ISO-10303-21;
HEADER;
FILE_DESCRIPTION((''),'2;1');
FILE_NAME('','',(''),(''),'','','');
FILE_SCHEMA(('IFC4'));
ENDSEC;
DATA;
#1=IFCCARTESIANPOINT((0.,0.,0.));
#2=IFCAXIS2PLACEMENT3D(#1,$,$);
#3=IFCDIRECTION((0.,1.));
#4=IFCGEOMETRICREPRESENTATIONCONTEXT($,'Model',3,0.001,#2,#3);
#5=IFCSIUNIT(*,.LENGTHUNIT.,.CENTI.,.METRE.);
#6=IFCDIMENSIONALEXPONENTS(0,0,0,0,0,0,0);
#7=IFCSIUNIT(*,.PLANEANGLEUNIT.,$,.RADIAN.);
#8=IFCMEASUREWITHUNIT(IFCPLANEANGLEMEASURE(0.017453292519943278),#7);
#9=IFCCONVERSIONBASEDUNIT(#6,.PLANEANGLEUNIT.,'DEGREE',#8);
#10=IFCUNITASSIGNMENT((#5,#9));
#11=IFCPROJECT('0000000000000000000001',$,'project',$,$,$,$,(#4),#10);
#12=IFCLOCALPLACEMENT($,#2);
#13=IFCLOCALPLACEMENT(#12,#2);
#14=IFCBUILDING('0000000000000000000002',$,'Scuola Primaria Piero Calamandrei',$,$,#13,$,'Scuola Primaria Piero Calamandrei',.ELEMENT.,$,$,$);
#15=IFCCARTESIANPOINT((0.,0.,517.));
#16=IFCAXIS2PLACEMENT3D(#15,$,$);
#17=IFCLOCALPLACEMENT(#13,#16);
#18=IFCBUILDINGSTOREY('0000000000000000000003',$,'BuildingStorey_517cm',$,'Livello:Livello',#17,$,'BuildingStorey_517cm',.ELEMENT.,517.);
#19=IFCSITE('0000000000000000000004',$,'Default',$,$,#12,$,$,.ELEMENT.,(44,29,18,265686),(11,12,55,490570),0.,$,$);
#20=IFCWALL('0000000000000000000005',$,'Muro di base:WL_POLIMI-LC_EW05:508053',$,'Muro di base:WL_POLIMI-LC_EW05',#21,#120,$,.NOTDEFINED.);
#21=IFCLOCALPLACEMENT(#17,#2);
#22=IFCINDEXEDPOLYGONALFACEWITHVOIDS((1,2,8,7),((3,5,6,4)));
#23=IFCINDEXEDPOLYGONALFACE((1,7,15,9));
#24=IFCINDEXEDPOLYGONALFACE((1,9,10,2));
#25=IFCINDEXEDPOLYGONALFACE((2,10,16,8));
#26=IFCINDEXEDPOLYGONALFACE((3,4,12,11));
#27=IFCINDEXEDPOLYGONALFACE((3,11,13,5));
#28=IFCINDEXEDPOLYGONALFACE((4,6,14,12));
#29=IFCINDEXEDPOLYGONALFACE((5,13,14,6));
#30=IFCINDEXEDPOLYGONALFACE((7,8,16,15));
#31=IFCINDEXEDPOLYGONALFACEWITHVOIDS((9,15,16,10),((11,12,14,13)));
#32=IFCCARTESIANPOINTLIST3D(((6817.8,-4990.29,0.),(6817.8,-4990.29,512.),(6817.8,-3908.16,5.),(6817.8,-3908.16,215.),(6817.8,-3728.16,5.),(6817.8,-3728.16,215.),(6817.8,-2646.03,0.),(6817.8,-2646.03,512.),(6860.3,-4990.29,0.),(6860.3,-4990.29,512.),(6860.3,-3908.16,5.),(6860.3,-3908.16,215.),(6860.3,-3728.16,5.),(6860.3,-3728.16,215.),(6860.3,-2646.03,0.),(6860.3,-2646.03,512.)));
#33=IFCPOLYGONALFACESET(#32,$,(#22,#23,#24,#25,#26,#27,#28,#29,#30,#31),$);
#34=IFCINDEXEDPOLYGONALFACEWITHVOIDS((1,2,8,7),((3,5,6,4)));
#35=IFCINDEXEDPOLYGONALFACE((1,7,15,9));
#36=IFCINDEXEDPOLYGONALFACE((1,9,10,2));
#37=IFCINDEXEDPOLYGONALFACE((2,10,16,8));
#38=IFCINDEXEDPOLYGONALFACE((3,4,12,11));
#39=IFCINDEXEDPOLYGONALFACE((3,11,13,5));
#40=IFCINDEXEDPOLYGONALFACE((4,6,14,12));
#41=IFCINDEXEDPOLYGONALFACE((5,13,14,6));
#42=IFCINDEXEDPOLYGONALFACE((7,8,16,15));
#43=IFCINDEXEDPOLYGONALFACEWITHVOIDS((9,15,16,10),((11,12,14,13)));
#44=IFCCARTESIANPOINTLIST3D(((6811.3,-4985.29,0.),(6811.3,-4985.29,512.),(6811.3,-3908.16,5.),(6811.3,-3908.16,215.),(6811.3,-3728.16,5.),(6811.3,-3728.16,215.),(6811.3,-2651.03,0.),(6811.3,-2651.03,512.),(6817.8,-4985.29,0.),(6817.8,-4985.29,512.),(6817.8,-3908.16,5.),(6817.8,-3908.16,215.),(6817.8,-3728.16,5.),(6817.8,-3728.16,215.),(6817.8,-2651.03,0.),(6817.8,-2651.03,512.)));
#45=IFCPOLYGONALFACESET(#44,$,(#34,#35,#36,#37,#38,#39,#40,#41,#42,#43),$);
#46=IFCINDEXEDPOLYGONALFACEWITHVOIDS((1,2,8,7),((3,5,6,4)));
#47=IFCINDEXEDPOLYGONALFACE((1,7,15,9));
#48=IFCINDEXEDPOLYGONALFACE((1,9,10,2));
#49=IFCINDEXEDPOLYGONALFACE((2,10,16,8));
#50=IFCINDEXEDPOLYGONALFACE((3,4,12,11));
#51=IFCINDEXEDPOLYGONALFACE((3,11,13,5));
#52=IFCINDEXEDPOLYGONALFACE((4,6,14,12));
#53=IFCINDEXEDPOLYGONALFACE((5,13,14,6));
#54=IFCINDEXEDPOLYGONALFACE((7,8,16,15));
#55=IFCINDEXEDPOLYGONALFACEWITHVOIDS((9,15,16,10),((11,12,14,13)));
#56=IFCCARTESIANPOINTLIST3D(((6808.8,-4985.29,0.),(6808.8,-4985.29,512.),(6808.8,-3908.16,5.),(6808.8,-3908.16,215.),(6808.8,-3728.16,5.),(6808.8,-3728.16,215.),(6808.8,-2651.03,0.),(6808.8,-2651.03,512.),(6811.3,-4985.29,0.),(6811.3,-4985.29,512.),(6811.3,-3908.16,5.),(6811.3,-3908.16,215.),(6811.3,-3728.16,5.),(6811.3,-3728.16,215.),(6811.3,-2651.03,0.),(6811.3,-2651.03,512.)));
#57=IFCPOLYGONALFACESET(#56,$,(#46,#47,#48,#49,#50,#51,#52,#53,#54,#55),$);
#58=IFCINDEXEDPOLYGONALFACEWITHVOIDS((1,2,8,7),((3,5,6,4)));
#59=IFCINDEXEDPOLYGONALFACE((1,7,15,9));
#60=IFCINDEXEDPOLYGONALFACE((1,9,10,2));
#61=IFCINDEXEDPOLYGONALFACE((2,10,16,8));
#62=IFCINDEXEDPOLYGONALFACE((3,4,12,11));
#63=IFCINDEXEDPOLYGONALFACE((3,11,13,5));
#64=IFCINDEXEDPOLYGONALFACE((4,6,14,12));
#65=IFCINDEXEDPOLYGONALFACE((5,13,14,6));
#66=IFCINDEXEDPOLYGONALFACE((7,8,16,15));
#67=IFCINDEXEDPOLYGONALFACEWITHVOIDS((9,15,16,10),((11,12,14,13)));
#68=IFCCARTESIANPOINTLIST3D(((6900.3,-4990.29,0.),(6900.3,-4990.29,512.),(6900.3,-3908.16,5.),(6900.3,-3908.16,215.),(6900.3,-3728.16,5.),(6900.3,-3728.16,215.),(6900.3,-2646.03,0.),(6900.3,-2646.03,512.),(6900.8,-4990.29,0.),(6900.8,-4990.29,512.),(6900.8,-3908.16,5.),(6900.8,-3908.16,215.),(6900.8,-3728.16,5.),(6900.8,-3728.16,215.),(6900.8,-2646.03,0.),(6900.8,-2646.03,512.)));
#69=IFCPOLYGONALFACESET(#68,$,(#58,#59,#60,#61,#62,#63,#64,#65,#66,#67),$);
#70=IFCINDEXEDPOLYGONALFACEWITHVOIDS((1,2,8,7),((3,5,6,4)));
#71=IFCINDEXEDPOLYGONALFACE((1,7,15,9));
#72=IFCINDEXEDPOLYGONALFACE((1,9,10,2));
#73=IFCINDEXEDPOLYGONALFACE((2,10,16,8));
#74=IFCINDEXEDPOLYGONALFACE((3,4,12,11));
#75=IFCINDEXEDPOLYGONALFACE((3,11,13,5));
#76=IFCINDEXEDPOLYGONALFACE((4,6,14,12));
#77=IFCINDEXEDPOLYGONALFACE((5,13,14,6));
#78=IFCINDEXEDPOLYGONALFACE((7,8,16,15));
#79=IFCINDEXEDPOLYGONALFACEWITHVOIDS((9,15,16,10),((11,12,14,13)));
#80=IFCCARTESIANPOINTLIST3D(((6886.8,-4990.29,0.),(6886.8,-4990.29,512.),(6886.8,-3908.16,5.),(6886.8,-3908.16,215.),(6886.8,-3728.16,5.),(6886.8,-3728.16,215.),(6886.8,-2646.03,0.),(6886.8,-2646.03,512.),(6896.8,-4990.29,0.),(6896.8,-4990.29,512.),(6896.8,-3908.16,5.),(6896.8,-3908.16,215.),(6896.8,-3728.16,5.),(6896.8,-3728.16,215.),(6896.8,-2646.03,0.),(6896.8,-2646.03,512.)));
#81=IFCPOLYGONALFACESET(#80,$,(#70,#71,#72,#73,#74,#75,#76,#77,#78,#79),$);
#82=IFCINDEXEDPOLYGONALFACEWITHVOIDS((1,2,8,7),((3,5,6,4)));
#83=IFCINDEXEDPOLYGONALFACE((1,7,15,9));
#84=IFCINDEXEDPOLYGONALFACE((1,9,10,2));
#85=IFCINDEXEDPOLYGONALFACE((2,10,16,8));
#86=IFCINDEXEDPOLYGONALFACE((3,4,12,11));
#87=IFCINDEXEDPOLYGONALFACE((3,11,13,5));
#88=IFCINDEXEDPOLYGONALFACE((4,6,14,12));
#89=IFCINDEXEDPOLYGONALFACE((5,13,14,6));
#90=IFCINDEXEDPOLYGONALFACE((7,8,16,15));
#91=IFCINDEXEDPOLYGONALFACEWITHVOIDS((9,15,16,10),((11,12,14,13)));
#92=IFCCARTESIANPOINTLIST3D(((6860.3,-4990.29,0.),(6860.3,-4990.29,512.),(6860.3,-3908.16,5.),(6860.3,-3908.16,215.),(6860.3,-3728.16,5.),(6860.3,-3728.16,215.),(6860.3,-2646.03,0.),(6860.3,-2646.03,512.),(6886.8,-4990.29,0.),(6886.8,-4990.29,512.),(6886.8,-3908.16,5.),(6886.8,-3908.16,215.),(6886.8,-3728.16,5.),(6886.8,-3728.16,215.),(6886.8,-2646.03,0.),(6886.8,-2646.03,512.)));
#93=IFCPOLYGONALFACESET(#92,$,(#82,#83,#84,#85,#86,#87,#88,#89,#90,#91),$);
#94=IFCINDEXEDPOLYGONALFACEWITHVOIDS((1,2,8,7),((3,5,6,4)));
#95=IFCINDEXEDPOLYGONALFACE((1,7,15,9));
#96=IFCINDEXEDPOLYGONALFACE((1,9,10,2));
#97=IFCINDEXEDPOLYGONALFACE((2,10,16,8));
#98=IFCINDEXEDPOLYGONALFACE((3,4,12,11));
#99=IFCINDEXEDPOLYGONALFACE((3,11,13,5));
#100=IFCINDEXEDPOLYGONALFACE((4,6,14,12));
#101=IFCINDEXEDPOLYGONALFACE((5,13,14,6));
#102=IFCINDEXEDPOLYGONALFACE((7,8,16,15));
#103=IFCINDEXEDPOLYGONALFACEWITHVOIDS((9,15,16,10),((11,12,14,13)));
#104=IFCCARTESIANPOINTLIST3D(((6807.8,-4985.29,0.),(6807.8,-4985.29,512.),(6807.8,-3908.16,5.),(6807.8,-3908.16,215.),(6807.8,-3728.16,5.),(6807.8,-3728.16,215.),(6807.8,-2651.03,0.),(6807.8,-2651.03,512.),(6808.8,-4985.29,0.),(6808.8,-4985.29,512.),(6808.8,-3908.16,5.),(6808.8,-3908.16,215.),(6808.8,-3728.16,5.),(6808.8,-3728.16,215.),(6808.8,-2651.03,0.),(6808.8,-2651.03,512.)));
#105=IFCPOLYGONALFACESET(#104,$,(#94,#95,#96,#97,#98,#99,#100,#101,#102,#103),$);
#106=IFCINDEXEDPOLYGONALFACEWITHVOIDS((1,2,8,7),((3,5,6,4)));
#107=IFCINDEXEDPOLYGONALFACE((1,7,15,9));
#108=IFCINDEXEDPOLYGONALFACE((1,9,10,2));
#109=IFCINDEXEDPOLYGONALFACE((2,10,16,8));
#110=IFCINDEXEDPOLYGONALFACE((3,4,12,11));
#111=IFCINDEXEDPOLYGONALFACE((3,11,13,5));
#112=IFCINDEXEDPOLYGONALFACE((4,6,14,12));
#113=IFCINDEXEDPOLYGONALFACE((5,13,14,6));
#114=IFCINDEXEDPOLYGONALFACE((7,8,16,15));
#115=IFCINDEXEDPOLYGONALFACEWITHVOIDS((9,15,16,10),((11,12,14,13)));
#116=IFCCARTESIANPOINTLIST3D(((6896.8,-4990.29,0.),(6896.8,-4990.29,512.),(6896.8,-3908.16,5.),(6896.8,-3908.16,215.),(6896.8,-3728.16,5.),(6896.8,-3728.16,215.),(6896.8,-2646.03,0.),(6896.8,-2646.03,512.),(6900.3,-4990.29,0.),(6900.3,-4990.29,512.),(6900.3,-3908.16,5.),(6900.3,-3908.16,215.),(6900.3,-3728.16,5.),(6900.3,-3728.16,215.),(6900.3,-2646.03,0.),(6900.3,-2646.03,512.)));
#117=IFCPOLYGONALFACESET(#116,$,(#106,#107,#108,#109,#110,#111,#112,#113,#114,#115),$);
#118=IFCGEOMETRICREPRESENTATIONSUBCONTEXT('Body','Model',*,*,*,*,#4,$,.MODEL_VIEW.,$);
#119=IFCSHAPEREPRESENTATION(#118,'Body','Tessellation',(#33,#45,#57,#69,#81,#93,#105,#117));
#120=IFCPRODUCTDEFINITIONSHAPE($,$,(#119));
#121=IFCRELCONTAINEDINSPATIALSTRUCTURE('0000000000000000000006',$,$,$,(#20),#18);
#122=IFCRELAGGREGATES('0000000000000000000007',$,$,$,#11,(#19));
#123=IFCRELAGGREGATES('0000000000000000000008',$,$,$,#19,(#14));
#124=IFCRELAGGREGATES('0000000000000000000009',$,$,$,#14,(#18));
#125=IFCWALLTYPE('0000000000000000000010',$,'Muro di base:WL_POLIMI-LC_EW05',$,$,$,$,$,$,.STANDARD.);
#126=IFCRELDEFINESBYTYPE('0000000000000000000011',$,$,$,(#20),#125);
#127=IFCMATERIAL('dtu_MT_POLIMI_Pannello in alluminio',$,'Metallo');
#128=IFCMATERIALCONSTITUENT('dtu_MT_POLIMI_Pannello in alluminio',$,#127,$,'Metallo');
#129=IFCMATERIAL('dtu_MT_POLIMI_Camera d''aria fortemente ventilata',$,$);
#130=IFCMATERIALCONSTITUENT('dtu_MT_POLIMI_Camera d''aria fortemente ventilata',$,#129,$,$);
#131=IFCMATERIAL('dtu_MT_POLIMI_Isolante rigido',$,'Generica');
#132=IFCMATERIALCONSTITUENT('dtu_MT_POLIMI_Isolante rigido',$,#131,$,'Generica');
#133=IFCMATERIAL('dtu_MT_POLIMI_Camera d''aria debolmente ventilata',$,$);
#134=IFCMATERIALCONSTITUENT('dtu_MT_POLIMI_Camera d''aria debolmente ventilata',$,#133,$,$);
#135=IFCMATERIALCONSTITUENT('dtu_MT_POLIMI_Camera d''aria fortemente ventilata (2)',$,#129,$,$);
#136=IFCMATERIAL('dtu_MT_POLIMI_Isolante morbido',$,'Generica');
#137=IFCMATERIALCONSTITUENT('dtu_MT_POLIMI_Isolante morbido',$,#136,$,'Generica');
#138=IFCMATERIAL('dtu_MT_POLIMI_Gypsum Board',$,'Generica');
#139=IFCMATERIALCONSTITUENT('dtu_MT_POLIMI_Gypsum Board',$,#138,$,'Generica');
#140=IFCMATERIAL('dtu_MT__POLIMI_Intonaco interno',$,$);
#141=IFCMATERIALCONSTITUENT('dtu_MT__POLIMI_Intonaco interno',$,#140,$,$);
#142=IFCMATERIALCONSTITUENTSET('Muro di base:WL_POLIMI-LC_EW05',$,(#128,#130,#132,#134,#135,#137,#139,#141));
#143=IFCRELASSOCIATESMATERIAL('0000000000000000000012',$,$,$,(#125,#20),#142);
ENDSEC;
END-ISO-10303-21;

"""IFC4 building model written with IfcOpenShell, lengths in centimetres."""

from ifc_helpers import new_model, entity, si_unit, converted_unit, direction, frame, origin, place, context, subcontext, project, spatial, indexed_curve, outline, extrude, material, constituent, constituent_set, type_object, element, save


model = new_model("IFC4")

# Units and contexts
model_context = context("Model", 3, precision=0.001, world=origin(), true_north=direction((0.0, 1.0)))
body_context = subcontext(model_context, "Body", "Model", "MODEL_VIEW")
ifc_project = project(units=[si_unit("LENGTHUNIT", "METRE", prefix="CENTI"), converted_unit("PLANEANGLEUNIT", "DEGREE", entity("IfcPlaneAngleMeasure", 0.017453292519943278), si_unit("PLANEANGLEUNIT", "RADIAN"), dimensions=[0, 0, 0, 0, 0, 0, 0])], contexts=[model_context])

# Site, building, storey
site_placement = place(None, origin())
site = spatial("IfcSite", under=ifc_project, at=site_placement, Name="Default", CompositionType="ELEMENT", RefLatitude=(44, 29, 18, 265686), RefLongitude=(11, 12, 55, 490570), RefElevation=0.0)
building_placement = place(site_placement, origin())
building = spatial("IfcBuilding", under=site, at=building_placement, Name="Scuola Primaria Piero Calamandrei", LongName="Scuola Primaria Piero Calamandrei", CompositionType="ELEMENT")
storey_placement = place(building_placement, frame((0.0, 0.0, 517.0)))
storey = spatial("IfcBuildingStorey", under=building, at=storey_placement, Name="BuildingStorey_517cm", ObjectType="Livello:Livello", LongName="BuildingStorey_517cm", CompositionType="ELEMENT", Elevation=517.0)

# Wall, opening
ifc_material_1 = material(Name="dtu_MT_POLIMI_Pannello in alluminio", Category="Metallo")
ifc_constituent_1 = constituent(ifc_material_1, Name="dtu_MT_POLIMI_Pannello in alluminio", Category="Metallo")
ifc_material_2 = material(Name="dtu_MT_POLIMI_Camera d'aria fortemente ventilata")
ifc_constituent_2 = constituent(ifc_material_2, Name="dtu_MT_POLIMI_Camera d'aria fortemente ventilata")
ifc_material_3 = material(Name="dtu_MT_POLIMI_Isolante rigido", Category="Generica")
ifc_constituent_3 = constituent(ifc_material_3, Name="dtu_MT_POLIMI_Isolante rigido", Category="Generica")
ifc_material_4 = material(Name="dtu_MT_POLIMI_Camera d'aria debolmente ventilata")
ifc_constituent_4 = constituent(ifc_material_4, Name="dtu_MT_POLIMI_Camera d'aria debolmente ventilata")
ifc_constituent_5 = constituent(ifc_material_2, Name="dtu_MT_POLIMI_Camera d'aria fortemente ventilata (2)")
ifc_material_5 = material(Name="dtu_MT_POLIMI_Isolante morbido", Category="Generica")
ifc_constituent_6 = constituent(ifc_material_5, Name="dtu_MT_POLIMI_Isolante morbido", Category="Generica")
ifc_material_6 = material(Name="dtu_MT_POLIMI_Gypsum Board", Category="Generica")
ifc_constituent_7 = constituent(ifc_material_6, Name="dtu_MT_POLIMI_Gypsum Board", Category="Generica")
ifc_material_7 = material(Name="dtu_MT__POLIMI_Intonaco interno")
ifc_constituent_8 = constituent(ifc_material_7, Name="dtu_MT__POLIMI_Intonaco interno")
ifc_constituent_set_1 = constituent_set(constituents=[ifc_constituent_1, ifc_constituent_2, ifc_constituent_3, ifc_constituent_4, ifc_constituent_5, ifc_constituent_6, ifc_constituent_7, ifc_constituent_8], Name="Muro di base:WL_POLIMI-LC_EW05")
wall_type_1 = type_object("IfcWallType", Name="Muro di base:WL_POLIMI-LC_EW05", PredefinedType="STANDARD", material=ifc_constituent_set_1)
wall_1_placement = place(storey_placement, frame((6854.3, -2646.03, 0.0), z_axis=(0.0, 0.0, 1.0), x_axis=(0.0, -1.0, 0.0)))
wall_1 = element("IfcWall", 1, at=wall_1_placement, inside=storey, type_object=wall_type_1, material=ifc_constituent_set_1, Name="Muro di base:WL_POLIMI-LC_EW05:508053", ObjectType="Muro di base:WL_POLIMI-LC_EW05", PredefinedType="NOTDEFINED", context=body_context, shape_type="SweptSolid", body=[
    extrude(outline(indexed_curve([(-256.0, -1172.13), (256.0, -1172.13), (256.0, 1172.13), (-256.0, 1172.13), (-256.0, -1172.13)], self_intersect=False), holes=[indexed_curve([(-251.0, -90.0), (-251.0, 90.0), (-41.0, 90.0), (-41.0, -90.0), (-251.0, -90.0)], self_intersect=False)]), frame((1172.13, -36.5, 256.0), z_axis=(0.0, 1.0, 0.0), x_axis=(0.0, 0.0, 1.0)), (0.0, 0.0, 1.0), 42.5),
    extrude(outline(indexed_curve([(-256.0, -1167.13), (256.0, -1167.13), (256.0, 1167.13), (-256.0, 1167.13), (-256.0, -1167.13)], self_intersect=False), holes=[indexed_curve([(-251.0, -90.0), (-251.0, 90.0), (-41.0, 90.0), (-41.0, -90.0), (-251.0, -90.0)], self_intersect=False)]), frame((1172.13, -43.0, 256.0), z_axis=(0.0, 1.0, 0.0), x_axis=(0.0, 0.0, 1.0)), (0.0, 0.0, 1.0), 6.5),
    extrude(outline(indexed_curve([(-256.0, -1167.13), (256.0, -1167.13), (256.0, 1167.13), (-256.0, 1167.13), (-256.0, -1167.13)], self_intersect=False), holes=[indexed_curve([(-251.0, -90.0), (-251.0, 90.0), (-41.0, 90.0), (-41.0, -90.0), (-251.0, -90.0)], self_intersect=False)]), frame((1172.13, -45.5, 256.0), z_axis=(0.0, 1.0, 0.0), x_axis=(0.0, 0.0, 1.0)), (0.0, 0.0, 1.0), 2.5),
    extrude(outline(indexed_curve([(-256.0, -1172.13), (256.0, -1172.13), (256.0, 1172.13), (-256.0, 1172.13), (-256.0, -1172.13)], self_intersect=False), holes=[indexed_curve([(-251.0, -90.0), (-251.0, 90.0), (-41.0, 90.0), (-41.0, -90.0), (-251.0, -90.0)], self_intersect=False)]), frame((1172.13, 46.0, 256.0), z_axis=(0.0, 1.0, 0.0), x_axis=(0.0, 0.0, 1.0)), (0.0, 0.0, 1.0), 0.5),
    extrude(outline(indexed_curve([(-256.0, -1172.13), (256.0, -1172.13), (256.0, 1172.13), (-256.0, 1172.13), (-256.0, -1172.13)], self_intersect=False), holes=[indexed_curve([(-251.0, -90.0), (-251.0, 90.0), (-41.0, 90.0), (-41.0, -90.0), (-251.0, -90.0)], self_intersect=False)]), frame((1172.13, 32.5, 256.0), z_axis=(0.0, 1.0, 0.0), x_axis=(0.0, 0.0, 1.0)), (0.0, 0.0, 1.0), 10.0),
    extrude(outline(indexed_curve([(-256.0, -1172.13), (256.0, -1172.13), (256.0, 1172.13), (-256.0, 1172.13), (-256.0, -1172.13)], self_intersect=False), holes=[indexed_curve([(-251.0, -90.0), (-251.0, 90.0), (-41.0, 90.0), (-41.0, -90.0), (-251.0, -90.0)], self_intersect=False)]), frame((1172.13, 6.0, 256.0), z_axis=(0.0, 1.0, 0.0), x_axis=(0.0, 0.0, 1.0)), (0.0, 0.0, 1.0), 26.5),
    extrude(outline(indexed_curve([(-256.0, -1167.13), (256.0, -1167.13), (256.0, 1167.13), (-256.0, 1167.13), (-256.0, -1167.13)], self_intersect=False), holes=[indexed_curve([(-41.0, -90.0), (-251.0, -90.0), (-251.0, 90.0), (-41.0, 90.0), (-41.0, -90.0)], self_intersect=False)]), frame((1172.13, -46.5, 256.0), z_axis=(0.0, 1.0, 0.0), x_axis=(0.0, 0.0, 1.0)), (0.0, 0.0, 1.0), 1.0),
    extrude(outline(indexed_curve([(-256.0, -1172.13), (256.0, -1172.13), (256.0, 1172.13), (-256.0, 1172.13), (-256.0, -1172.13)], self_intersect=False), holes=[indexed_curve([(-251.0, -90.0), (-251.0, 90.0), (-41.0, 90.0), (-41.0, -90.0), (-251.0, -90.0)], self_intersect=False)]), frame((1172.13, 42.5, 256.0), z_axis=(0.0, 1.0, 0.0), x_axis=(0.0, 0.0, 1.0)), (0.0, 0.0, 1.0), 3.5),
])
opening_1_placement = place(wall_1_placement, frame((1082.13, -46.5, 5.0)))
element("IfcOpeningElement", 2, at=opening_1_placement, cuts=wall_1, PredefinedType="OPENING", context=body_context, shape_type="SweptSolid", body=[
    extrude(outline(indexed_curve([(210.0, 0.0), (210.0, 180.0), (0.0, 180.0), (0.0, 0.0), (210.0, 0.0)], self_intersect=False)), frame((0.0, 0.0, 0.0), z_axis=(0.0, 1.0, 0.0), x_axis=(0.0, 0.0, 1.0)), (0.0, 0.0, 1.0), 93.0),
])

save(model, "model.ifc")
